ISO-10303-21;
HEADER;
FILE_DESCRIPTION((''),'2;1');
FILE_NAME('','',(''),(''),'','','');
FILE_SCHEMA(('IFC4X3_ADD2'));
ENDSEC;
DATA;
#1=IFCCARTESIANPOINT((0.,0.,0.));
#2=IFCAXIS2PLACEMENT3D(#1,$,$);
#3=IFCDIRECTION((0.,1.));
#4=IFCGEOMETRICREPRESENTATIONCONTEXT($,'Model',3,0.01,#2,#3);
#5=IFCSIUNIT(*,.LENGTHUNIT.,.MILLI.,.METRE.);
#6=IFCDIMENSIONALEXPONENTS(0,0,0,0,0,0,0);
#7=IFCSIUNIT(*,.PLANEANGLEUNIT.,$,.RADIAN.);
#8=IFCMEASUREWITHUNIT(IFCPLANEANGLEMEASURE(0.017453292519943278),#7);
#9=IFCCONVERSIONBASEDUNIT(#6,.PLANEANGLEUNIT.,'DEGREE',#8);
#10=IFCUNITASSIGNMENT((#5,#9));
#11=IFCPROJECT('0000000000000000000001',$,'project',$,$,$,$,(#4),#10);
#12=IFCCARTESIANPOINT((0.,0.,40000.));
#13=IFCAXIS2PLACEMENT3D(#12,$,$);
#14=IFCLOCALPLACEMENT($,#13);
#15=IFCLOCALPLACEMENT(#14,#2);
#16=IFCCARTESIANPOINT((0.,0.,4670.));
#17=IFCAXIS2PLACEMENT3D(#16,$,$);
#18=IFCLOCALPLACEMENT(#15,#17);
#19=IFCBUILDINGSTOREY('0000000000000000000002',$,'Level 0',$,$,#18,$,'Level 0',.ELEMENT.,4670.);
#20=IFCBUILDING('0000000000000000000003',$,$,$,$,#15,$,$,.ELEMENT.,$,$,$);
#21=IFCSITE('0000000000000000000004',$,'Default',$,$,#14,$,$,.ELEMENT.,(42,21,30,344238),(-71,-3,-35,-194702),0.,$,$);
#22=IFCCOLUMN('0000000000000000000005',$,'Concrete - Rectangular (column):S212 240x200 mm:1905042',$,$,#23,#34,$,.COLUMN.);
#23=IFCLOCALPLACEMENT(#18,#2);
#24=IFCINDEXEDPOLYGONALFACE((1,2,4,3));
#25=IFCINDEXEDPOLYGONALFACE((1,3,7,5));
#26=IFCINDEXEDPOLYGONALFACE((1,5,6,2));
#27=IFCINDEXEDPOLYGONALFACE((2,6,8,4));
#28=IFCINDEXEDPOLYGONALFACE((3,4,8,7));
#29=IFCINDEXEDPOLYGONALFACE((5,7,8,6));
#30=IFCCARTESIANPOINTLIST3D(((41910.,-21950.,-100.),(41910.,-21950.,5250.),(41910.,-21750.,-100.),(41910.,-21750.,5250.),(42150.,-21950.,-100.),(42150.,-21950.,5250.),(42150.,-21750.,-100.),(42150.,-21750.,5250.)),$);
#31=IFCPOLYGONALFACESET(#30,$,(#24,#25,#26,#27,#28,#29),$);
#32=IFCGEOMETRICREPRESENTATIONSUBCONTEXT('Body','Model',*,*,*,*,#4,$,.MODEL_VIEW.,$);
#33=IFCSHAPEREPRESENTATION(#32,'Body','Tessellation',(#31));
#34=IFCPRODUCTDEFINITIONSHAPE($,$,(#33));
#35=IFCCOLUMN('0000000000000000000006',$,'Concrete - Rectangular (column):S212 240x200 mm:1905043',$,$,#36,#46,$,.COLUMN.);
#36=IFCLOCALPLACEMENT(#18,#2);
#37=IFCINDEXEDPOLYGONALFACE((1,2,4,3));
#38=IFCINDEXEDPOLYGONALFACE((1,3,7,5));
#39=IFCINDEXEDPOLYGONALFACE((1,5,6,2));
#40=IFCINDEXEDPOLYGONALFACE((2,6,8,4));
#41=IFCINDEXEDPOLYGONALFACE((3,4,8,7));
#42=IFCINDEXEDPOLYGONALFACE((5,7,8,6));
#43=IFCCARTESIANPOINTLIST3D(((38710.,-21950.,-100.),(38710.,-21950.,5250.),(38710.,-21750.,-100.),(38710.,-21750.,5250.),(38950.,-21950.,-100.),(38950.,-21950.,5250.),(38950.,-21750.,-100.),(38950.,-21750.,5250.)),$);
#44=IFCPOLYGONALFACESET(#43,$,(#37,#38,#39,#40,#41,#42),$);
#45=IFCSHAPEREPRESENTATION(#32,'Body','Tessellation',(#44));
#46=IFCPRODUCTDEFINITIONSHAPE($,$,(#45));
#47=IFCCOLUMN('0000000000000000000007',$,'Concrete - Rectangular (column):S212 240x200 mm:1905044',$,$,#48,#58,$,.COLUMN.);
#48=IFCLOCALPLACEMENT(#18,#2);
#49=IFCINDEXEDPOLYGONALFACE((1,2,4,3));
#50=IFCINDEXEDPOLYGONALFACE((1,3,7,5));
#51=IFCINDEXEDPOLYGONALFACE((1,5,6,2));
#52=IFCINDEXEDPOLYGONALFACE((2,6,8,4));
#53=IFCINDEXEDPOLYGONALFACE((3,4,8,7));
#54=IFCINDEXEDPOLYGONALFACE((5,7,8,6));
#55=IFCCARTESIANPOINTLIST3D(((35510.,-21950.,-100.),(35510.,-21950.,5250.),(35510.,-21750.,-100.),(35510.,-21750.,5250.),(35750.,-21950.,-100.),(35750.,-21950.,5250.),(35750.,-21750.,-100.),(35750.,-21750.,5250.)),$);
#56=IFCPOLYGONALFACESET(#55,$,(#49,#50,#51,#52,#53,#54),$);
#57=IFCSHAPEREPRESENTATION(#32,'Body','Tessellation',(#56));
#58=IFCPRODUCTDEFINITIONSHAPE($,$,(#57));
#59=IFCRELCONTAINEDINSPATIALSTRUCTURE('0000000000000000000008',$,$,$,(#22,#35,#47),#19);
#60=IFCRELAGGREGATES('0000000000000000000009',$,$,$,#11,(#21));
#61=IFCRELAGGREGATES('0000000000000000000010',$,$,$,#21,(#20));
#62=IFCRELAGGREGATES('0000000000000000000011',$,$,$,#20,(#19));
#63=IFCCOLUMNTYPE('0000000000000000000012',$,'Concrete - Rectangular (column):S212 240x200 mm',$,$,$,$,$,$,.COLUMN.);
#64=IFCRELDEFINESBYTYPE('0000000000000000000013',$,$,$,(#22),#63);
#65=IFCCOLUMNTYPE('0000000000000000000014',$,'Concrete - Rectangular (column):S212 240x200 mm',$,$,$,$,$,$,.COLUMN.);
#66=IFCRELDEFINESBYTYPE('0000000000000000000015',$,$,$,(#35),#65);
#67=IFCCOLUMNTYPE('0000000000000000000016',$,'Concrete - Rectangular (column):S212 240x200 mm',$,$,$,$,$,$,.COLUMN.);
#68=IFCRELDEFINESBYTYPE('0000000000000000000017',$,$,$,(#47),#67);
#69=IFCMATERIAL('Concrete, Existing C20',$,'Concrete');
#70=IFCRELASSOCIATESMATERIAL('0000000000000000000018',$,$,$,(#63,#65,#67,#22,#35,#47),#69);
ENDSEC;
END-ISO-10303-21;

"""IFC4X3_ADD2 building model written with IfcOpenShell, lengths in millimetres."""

from ifc_helpers import new_model, entity, si_unit, converted_unit, direction, frame, frame_2d, origin, origin_2d_with_axis, place, context, subcontext, project, spatial, rectangle, extrude, source, transform, mapped, material, material_profile, profile_set, profile_usage, type_object, type_shapes, element, save


model = new_model("IFC4X3_ADD2")

# Units and contexts
model_context = context("Model", 3, precision=0.01, world=origin(), true_north=direction((0.0, 1.0)))
body_context = subcontext(model_context, "Body", "Model", "MODEL_VIEW")
ifc_project = project(units=[si_unit("LENGTHUNIT", "METRE", prefix="MILLI"), converted_unit("PLANEANGLEUNIT", "DEGREE", entity("IfcPlaneAngleMeasure", 0.017453292519943278), si_unit("PLANEANGLEUNIT", "RADIAN"), dimensions=[0, 0, 0, 0, 0, 0, 0])], contexts=[model_context])

# Site, building, storey
site_placement = place(None, frame((0.0, 0.0, 40000.0)))
site = spatial("IfcSite", under=ifc_project, at=site_placement, Name="Default", CompositionType="ELEMENT", RefLatitude=(42, 21, 30, 344238), RefLongitude=(-71, -3, -35, -194702), RefElevation=0.0)
building_placement = place(site_placement, origin())
building = spatial("IfcBuilding", under=site, at=building_placement, CompositionType="ELEMENT")
storey_placement = place(building_placement, frame((0.0, 0.0, 4670.0)))
storey = spatial("IfcBuildingStorey", under=building, at=storey_placement, Name="Level 0", LongName="Level 0", CompositionType="ELEMENT", Elevation=4670.0)

# Columns
ifc_material = material(Name="Concrete, Existing C20", Category="Concrete")
ifc_material_profile_1 = material_profile(ifc_material, rectangle(XDim=200.0, YDim=240.0, at=frame_2d((0.0, 0.0), x_axis=(1.0, 0.0))), Name="S212 240x200 mm")
ifc_profile_set_1 = profile_set([ifc_material_profile_1], Name="S212 240x200 mm")
ifc_profile_usage_1 = profile_usage(ifc_profile_set_1)
column_type_1 = type_object("IfcColumnType", Name="Concrete - Rectangular (column):S212 240x200 mm", PredefinedType="COLUMN", material=ifc_profile_set_1)
shared_shape_1 = source(origin(), body_context, "Body", "SweptSolid", [
    extrude(rectangle(XDim=200.0, YDim=240.0, at=origin_2d_with_axis()), frame((42030.0, -21850.0, 4570.0), z_axis=(0.0, 0.0, 1.0), x_axis=(0.0, 1.0, 0.0)), (0.0, 0.0, 1.0), 5350.0),
])
type_shapes(column_type_1, [shared_shape_1])
column_1_placement = place(storey_placement, frame((0.0, 0.0, -4670.0)))
element("IfcColumn", 1, at=column_1_placement, inside=storey, type_object=column_type_1, material=ifc_profile_usage_1, Name="Concrete - Rectangular (column):S212 240x200 mm:1905042", PredefinedType="COLUMN", context=body_context, shape_type="MappedRepresentation", body=[
    mapped(shared_shape_1, transform((0.0, 0.0, 0.0), scale=1.0)),
])
column_type_2 = type_object("IfcColumnType", Name="Concrete - Rectangular (column):S212 240x200 mm", PredefinedType="COLUMN", material=ifc_profile_set_1)
shared_shape_2 = source(origin(), body_context, "Body", "SweptSolid", [
    extrude(rectangle(XDim=200.0, YDim=240.0, at=frame_2d((0.0, 0.0), x_axis=(1.0, 0.0))), frame((38830.0, -21850.0, 4570.0), z_axis=(0.0, 0.0, 1.0), x_axis=(0.0, 1.0, 0.0)), (0.0, 0.0, 1.0), 5350.0),
])
type_shapes(column_type_2, [shared_shape_2])
column_2_placement = place(storey_placement, frame((0.0, 0.0, -4670.0)))
element("IfcColumn", 2, at=column_2_placement, inside=storey, type_object=column_type_2, material=ifc_profile_usage_1, Name="Concrete - Rectangular (column):S212 240x200 mm:1905043", PredefinedType="COLUMN", context=body_context, shape_type="MappedRepresentation", body=[
    mapped(shared_shape_2, transform((0.0, 0.0, 0.0), scale=1.0)),
])
column_type_3 = type_object("IfcColumnType", Name="Concrete - Rectangular (column):S212 240x200 mm", PredefinedType="COLUMN", material=ifc_profile_set_1)
shared_shape_3 = source(origin(), body_context, "Body", "SweptSolid", [
    extrude(rectangle(XDim=200.0, YDim=240.0, at=frame_2d((0.0, 0.0), x_axis=(1.0, 0.0))), frame((35630.0, -21850.0, 4570.0), z_axis=(0.0, 0.0, 1.0), x_axis=(0.0, 1.0, 0.0)), (0.0, 0.0, 1.0), 5350.0),
])
type_shapes(column_type_3, [shared_shape_3])
column_3_placement = place(storey_placement, frame((0.0, 0.0, -4670.0)))
element("IfcColumn", 3, at=column_3_placement, inside=storey, type_object=column_type_3, material=ifc_profile_usage_1, Name="Concrete - Rectangular (column):S212 240x200 mm:1905044", PredefinedType="COLUMN", context=body_context, shape_type="MappedRepresentation", body=[
    mapped(shared_shape_3, transform((0.0, 0.0, 0.0), scale=1.0)),
])

save(model, "model.ifc")
